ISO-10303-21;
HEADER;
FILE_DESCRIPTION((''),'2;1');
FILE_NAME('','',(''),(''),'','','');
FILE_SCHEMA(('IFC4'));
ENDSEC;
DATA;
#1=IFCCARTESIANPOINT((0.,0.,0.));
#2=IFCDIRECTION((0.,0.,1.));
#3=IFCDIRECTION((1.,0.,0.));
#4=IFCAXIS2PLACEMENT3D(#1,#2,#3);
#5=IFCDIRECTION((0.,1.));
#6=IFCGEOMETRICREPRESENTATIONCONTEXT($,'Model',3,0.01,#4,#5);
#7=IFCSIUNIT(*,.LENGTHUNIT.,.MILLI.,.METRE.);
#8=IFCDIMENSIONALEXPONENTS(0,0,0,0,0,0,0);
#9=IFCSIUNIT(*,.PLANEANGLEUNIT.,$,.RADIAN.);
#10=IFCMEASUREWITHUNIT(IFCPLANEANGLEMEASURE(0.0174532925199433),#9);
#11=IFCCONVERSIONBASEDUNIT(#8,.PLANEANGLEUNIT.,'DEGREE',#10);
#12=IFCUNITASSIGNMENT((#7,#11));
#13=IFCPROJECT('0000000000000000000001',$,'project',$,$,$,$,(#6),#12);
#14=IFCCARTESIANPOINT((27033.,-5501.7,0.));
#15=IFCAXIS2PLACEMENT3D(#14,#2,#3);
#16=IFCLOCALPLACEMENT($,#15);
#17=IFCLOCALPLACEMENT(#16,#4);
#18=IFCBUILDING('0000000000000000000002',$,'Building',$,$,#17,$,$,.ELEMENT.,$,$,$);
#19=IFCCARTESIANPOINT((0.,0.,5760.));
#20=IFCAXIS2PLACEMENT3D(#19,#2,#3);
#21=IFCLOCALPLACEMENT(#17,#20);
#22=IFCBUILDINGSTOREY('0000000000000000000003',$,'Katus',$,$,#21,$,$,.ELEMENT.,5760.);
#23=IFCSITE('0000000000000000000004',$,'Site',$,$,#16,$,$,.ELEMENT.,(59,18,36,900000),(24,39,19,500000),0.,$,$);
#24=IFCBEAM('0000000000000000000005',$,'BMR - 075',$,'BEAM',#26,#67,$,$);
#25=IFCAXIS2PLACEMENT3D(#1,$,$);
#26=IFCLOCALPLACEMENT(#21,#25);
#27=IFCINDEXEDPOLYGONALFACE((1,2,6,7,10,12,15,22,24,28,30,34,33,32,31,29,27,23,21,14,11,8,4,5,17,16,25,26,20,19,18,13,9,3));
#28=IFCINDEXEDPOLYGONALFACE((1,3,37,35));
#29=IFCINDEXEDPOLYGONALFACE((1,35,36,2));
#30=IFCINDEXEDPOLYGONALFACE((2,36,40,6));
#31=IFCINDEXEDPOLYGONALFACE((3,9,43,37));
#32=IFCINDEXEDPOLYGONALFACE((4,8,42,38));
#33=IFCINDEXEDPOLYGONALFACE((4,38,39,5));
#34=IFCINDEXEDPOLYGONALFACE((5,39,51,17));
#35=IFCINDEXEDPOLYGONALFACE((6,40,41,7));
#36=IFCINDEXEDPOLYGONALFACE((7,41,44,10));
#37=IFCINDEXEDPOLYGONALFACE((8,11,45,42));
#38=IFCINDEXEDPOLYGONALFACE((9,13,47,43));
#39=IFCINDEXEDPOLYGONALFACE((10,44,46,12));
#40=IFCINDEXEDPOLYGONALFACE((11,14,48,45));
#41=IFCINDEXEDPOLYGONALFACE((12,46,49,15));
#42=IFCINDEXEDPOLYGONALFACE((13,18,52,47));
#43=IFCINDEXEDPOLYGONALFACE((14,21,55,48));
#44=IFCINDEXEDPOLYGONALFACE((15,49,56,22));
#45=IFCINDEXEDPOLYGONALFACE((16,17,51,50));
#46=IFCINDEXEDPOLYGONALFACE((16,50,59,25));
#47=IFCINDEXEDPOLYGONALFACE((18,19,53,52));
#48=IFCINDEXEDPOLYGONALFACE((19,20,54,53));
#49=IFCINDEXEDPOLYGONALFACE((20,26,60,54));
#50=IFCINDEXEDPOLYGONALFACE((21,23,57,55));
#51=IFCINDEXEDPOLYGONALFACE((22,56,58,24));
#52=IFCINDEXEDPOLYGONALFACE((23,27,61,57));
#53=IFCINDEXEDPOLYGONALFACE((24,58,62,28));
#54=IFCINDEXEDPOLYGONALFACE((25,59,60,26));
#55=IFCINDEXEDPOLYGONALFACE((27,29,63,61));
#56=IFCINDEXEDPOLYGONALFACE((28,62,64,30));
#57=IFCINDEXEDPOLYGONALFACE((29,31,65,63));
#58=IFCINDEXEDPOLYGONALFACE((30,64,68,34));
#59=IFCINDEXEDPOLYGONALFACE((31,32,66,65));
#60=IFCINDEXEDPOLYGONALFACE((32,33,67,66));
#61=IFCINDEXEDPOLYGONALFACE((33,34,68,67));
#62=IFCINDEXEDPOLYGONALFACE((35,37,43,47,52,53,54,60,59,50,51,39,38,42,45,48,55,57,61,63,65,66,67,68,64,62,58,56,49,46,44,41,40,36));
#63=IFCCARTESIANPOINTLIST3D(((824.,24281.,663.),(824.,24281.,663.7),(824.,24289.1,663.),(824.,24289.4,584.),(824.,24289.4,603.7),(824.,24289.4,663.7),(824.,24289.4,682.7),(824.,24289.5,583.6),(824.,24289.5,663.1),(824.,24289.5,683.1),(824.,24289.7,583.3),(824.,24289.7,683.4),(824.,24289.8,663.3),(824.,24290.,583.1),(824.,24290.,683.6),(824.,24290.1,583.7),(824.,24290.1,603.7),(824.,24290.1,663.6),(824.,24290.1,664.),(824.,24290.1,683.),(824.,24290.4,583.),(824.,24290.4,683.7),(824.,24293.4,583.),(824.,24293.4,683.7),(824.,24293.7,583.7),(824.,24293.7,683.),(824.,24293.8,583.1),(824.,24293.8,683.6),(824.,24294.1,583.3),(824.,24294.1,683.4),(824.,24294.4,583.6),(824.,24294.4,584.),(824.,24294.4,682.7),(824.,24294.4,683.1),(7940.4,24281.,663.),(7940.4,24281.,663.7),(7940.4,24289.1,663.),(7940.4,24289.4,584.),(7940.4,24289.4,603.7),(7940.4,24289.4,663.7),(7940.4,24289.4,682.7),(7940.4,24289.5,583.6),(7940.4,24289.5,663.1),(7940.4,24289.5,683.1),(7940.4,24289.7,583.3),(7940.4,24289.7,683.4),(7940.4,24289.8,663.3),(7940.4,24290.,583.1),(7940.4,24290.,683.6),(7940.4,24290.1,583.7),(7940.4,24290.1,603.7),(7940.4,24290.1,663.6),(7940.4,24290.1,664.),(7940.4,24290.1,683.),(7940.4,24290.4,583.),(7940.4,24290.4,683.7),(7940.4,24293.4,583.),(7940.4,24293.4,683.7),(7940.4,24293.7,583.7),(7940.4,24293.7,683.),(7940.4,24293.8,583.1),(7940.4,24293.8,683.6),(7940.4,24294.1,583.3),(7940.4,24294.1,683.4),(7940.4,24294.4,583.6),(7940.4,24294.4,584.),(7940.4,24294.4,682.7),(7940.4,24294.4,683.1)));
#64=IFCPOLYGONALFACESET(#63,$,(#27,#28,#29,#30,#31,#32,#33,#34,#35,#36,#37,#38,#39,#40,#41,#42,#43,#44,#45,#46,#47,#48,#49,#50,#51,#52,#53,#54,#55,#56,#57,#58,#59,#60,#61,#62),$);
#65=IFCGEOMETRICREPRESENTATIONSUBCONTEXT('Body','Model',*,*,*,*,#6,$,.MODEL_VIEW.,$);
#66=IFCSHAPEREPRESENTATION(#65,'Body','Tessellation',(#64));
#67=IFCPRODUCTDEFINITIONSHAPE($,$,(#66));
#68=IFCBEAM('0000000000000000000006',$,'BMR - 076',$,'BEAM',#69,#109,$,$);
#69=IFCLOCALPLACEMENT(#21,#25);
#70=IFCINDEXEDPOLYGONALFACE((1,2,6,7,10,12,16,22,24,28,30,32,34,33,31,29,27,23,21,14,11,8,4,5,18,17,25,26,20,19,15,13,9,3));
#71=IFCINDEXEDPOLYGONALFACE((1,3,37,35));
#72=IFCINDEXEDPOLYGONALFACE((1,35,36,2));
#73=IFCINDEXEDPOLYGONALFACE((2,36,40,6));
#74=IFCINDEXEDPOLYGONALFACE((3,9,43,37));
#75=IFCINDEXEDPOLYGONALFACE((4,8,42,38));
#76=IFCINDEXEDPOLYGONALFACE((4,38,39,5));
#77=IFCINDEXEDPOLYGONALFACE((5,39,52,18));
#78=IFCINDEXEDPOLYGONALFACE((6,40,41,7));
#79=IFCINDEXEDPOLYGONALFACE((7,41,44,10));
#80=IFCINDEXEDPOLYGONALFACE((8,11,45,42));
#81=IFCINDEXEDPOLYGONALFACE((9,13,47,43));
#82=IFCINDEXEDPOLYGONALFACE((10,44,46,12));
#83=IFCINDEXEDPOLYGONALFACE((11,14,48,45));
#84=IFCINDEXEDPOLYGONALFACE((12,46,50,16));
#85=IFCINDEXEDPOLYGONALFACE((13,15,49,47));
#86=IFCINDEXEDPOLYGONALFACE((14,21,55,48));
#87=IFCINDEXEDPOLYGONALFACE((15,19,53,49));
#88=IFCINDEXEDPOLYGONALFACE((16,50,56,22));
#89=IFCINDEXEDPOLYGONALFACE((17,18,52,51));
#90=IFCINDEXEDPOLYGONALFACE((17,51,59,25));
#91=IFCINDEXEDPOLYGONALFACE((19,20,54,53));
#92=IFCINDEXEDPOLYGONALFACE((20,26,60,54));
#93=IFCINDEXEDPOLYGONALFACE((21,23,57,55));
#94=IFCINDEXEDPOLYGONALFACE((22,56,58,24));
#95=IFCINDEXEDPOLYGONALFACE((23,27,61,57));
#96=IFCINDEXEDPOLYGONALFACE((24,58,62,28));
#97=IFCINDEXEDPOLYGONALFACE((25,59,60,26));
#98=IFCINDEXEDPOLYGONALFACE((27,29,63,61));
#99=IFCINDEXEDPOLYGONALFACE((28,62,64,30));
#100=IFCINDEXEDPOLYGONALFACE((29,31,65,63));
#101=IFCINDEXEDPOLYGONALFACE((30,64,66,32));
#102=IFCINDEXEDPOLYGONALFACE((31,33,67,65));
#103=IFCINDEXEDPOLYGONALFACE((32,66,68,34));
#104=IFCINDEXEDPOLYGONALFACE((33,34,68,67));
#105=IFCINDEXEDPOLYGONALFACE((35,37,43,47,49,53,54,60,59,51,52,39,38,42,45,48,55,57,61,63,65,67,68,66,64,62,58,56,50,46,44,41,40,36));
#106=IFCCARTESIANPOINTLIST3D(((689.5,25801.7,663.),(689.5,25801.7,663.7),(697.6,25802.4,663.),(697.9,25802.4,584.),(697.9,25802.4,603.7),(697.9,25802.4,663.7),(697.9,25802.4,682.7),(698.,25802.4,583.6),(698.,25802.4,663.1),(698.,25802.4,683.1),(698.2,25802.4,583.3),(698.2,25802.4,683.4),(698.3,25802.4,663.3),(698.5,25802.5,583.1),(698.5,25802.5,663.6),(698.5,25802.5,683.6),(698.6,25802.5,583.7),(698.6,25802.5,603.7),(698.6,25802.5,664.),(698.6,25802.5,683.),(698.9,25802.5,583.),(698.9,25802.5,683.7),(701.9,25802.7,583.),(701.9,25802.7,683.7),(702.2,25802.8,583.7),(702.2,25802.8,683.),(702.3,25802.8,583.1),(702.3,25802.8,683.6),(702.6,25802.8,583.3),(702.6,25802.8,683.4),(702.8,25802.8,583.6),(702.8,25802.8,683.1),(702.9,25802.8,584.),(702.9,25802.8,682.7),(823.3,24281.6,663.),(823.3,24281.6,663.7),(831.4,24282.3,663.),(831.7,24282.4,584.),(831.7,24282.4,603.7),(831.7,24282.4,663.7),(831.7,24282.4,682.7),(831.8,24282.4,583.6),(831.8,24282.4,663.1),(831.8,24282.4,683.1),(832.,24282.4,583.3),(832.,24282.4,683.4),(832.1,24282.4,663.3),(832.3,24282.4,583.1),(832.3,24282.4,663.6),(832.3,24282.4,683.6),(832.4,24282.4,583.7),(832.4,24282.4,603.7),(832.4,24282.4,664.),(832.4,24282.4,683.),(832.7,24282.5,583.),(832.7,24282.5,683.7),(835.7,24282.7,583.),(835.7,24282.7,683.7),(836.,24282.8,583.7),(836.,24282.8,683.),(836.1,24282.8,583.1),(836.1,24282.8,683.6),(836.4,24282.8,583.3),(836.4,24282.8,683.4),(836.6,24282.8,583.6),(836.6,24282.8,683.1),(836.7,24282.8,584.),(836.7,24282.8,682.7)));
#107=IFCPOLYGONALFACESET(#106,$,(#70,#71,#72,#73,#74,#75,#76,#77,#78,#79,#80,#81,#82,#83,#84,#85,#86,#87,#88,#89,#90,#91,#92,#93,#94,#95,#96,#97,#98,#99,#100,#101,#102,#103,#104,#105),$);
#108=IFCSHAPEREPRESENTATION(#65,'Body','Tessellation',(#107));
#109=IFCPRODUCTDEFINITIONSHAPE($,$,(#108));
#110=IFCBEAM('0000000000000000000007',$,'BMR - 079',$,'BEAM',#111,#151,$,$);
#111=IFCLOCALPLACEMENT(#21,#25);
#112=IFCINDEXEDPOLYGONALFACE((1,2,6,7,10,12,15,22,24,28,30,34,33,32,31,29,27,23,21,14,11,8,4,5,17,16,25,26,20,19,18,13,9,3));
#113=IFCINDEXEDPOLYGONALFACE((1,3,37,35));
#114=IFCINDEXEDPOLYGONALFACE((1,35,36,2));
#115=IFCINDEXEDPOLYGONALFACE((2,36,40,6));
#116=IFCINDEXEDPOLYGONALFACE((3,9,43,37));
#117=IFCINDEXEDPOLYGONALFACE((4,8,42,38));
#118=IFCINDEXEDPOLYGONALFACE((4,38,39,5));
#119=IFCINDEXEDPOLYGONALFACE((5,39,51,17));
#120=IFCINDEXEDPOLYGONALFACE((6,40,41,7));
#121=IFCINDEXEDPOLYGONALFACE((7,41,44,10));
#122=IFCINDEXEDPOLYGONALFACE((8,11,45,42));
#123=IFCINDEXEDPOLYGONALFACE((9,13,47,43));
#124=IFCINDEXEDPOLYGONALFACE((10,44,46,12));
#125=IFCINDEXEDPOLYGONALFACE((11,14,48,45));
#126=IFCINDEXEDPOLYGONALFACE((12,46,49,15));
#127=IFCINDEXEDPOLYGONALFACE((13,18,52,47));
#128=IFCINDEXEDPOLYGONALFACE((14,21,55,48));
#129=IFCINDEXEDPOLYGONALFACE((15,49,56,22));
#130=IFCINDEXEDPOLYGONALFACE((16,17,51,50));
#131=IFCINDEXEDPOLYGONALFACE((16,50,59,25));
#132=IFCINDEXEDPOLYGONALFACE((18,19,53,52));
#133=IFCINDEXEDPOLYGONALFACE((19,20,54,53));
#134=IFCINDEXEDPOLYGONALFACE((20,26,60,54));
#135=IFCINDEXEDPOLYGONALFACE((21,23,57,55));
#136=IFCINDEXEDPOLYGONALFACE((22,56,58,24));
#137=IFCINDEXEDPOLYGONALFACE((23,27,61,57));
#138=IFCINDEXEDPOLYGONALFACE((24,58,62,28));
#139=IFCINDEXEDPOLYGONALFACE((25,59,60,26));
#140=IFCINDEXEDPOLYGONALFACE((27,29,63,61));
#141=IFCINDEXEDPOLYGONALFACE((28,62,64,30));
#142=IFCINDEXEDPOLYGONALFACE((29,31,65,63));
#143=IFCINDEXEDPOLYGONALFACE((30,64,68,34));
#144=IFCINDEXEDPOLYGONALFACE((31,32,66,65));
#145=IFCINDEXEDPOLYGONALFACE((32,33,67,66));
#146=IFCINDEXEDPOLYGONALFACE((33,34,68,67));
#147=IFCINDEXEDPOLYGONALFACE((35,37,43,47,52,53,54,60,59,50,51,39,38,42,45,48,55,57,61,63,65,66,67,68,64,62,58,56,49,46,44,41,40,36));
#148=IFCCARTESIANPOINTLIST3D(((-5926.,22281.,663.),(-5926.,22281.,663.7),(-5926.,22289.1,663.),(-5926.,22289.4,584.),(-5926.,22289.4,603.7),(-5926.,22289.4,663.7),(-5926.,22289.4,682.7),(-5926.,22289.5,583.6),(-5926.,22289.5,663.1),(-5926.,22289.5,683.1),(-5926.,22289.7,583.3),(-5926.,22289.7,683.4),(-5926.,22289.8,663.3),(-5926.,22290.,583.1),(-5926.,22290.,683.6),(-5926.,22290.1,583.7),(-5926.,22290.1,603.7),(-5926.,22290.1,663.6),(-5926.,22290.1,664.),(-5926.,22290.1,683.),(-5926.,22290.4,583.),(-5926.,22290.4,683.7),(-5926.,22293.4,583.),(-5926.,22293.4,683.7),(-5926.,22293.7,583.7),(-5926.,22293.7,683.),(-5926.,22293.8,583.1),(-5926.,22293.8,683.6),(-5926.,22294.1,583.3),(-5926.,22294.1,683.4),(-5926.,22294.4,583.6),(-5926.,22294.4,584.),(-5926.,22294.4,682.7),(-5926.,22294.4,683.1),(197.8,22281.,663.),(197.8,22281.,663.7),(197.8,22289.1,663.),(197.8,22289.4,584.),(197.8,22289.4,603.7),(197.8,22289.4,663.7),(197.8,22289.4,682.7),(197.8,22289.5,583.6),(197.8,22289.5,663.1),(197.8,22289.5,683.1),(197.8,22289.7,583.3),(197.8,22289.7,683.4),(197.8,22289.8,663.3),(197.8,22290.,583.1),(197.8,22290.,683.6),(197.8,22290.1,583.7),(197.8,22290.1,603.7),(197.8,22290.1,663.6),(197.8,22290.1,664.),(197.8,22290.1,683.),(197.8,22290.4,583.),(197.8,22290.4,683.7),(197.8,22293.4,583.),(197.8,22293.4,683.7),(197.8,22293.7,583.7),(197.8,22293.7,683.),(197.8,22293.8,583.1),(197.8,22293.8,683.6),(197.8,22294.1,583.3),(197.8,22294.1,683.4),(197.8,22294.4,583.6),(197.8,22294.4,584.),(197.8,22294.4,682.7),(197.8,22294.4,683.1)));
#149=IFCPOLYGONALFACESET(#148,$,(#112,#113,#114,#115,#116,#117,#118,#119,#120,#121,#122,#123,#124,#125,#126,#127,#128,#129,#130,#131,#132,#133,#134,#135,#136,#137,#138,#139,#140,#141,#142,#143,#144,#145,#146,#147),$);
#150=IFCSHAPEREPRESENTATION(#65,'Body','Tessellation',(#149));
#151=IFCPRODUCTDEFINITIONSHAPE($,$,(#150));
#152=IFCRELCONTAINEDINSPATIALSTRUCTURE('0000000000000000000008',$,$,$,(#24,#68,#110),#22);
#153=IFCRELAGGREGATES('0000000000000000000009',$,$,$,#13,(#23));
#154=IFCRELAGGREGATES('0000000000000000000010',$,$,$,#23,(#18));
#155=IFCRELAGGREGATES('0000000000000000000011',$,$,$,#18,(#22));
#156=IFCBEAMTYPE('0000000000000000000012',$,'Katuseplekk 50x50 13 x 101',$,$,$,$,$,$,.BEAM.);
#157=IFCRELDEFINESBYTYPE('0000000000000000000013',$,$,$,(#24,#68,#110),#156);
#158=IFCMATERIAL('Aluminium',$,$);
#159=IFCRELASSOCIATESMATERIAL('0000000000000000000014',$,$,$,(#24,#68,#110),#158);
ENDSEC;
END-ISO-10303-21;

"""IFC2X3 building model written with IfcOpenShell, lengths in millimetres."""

from ifc_helpers import new_model, entity, si_unit, converted_unit, point, direction, frame, frame_2d, origin_with_axes, place, context, subcontext, project, spatial, polyline, circle_curve, parameter, trimmed, segment, composite_curve, outline, extrude, material, type_object, element, save


model = new_model("IFC2X3")

# Units and contexts
model_context = context("Model", 3, precision=0.01, world=origin_with_axes(), true_north=direction((0.0, 1.0)))
body_context = subcontext(model_context, "Body", "Model", "MODEL_VIEW")
ifc_project = project(units=[si_unit("LENGTHUNIT", "METRE", prefix="MILLI"), converted_unit("PLANEANGLEUNIT", "DEGREE", entity("IfcPlaneAngleMeasure", 0.0174532925199433), si_unit("PLANEANGLEUNIT", "RADIAN"), dimensions=[0, 0, 0, 0, 0, 0, 0])], contexts=[model_context])

# Site, building, storey
site_placement = place(None, frame((27033.0, -5501.7, 0.0), z_axis=(0.0, 0.0, 1.0), x_axis=(1.0, 0.0, 0.0)))
site = spatial("IfcSite", under=ifc_project, at=site_placement, Name="Site", CompositionType="ELEMENT", RefLatitude=(59, 18, 36, 900000), RefLongitude=(24, 39, 19, 500000), RefElevation=0.0)
building_placement = place(site_placement, origin_with_axes())
building = spatial("IfcBuilding", under=site, at=building_placement, Name="Building", CompositionType="ELEMENT")
storey_placement = place(building_placement, frame((0.0, 0.0, 5760.0), z_axis=(0.0, 0.0, 1.0), x_axis=(1.0, 0.0, 0.0)))
storey = spatial("IfcBuildingStorey", under=building, at=storey_placement, Name="Katus", CompositionType="ELEMENT", Elevation=5760.0)

# Beams
ifc_material_1 = material(Name="Aluminium")
beam_type = type_object("IfcBeamType", Name="Katuseplekk 50x50 13 x 101", PredefinedType="BEAM")
beam_1_placement = place(storey_placement, frame((7940.4, 24281.7, 663.0), z_axis=(0.0, 0.0, 1.0), x_axis=(0.0, 1.0, 0.0)))
element("IfcBeam", 1, at=beam_1_placement, inside=storey, type_object=beam_type, material=ifc_material_1, Name="BMR - 075", ObjectType="BEAM", context=body_context, shape_type="SweptSolid", body=[
    extrude(outline(composite_curve([segment(polyline([(-0.7, 0.0), (7.4, 0.0)]), True, "CONTINUOUS"), segment(trimmed(circle_curve(frame_2d((7.4, 1.0), x_axis=(0.0, -1.0)), 1.0), [point((7.4, 0.0)), parameter(0.0)], [point((8.4, 1.0)), parameter(90.0)], True, "CARTESIAN"), True, "CONTINUOUS"), segment(polyline([(8.4, 1.0), (8.4, 20.0), (12.0, 20.0), (12.0, -79.3), (8.4, -79.3), (8.4, -59.3), (7.7, -59.3), (7.7, -79.0)]), True, "CONTINUOUS"), segment(trimmed(circle_curve(frame_2d((8.7, -79.0), x_axis=(-1.0, 0.0)), 1.0), [point((7.7, -79.0)), parameter(0.0)], [point((8.7, -80.0)), parameter(90.0)], True, "CARTESIAN"), True, "CONTINUOUS"), segment(polyline([(8.7, -80.0), (11.7, -80.0)]), True, "CONTINUOUS"), segment(trimmed(circle_curve(frame_2d((11.7, -79.0), x_axis=(0.0, -1.0)), 1.0), [point((11.7, -80.0)), parameter(0.0)], [point((12.7, -79.0)), parameter(90.0)], True, "CARTESIAN"), True, "CONTINUOUS"), segment(polyline([(12.7, -79.0), (12.7, 19.7)]), True, "CONTINUOUS"), segment(trimmed(circle_curve(frame_2d((11.7, 19.7), x_axis=(1.0, 0.0)), 1.0), [point((12.7, 19.7)), parameter(0.0)], [point((11.7, 20.7)), parameter(90.0)], True, "CARTESIAN"), True, "CONTINUOUS"), segment(polyline([(11.7, 20.7), (8.7, 20.7)]), True, "CONTINUOUS"), segment(trimmed(circle_curve(frame_2d((8.7, 19.7), x_axis=(0.0, 1.0)), 1.0), [point((8.7, 20.7)), parameter(0.0)], [point((7.7, 19.7)), parameter(90.0)], True, "CARTESIAN"), True, "CONTINUOUS"), segment(polyline([(7.7, 19.7), (7.7, 0.7), (-0.7, 0.7), (-0.7, 0.0)]), True, "CONTINUOUS")], self_intersect=False)), frame((0.0, 7116.4, 0.0), z_axis=(0.0, -1.0, 0.0), x_axis=(1.0, 0.0, 0.0)), (0.0, 0.0, 1.0), 7116.4),
])
beam_2_placement = place(storey_placement, frame((824.0, 24281.7, 663.0), z_axis=(0.0, 0.0, 1.0), x_axis=(0.996146, 0.087712, 0.0)))
element("IfcBeam", 2, at=beam_2_placement, inside=storey, type_object=beam_type, material=ifc_material_1, Name="BMR - 076", ObjectType="BEAM", context=body_context, shape_type="SweptSolid", body=[
    extrude(outline(composite_curve([segment(polyline([(-0.7, 0.0), (7.4, 0.0)]), True, "CONTINUOUS"), segment(trimmed(circle_curve(frame_2d((7.4, 1.0), x_axis=(0.0, -1.0)), 1.0), [point((7.4, 0.0)), parameter(0.0)], [point((8.4, 1.0)), parameter(90.0)], True, "CARTESIAN"), True, "CONTINUOUS"), segment(polyline([(8.4, 1.0), (8.4, 20.0), (12.0, 20.0), (12.0, -79.3), (8.4, -79.3), (8.4, -59.3), (7.7, -59.3), (7.7, -79.0)]), True, "CONTINUOUS"), segment(trimmed(circle_curve(frame_2d((8.7, -79.0), x_axis=(-1.0, 0.0)), 1.0), [point((7.7, -79.0)), parameter(0.0)], [point((8.7, -80.0)), parameter(90.0)], True, "CARTESIAN"), True, "CONTINUOUS"), segment(polyline([(8.7, -80.0), (11.7, -80.0)]), True, "CONTINUOUS"), segment(trimmed(circle_curve(frame_2d((11.7, -79.0), x_axis=(0.0, -1.0)), 1.0), [point((11.7, -80.0)), parameter(0.0)], [point((12.7, -79.0)), parameter(90.0)], True, "CARTESIAN"), True, "CONTINUOUS"), segment(polyline([(12.7, -79.0), (12.7, 19.7)]), True, "CONTINUOUS"), segment(trimmed(circle_curve(frame_2d((11.7, 19.7), x_axis=(1.0, 0.0)), 1.0), [point((12.7, 19.7)), parameter(0.0)], [point((11.7, 20.7)), parameter(90.0)], True, "CARTESIAN"), True, "CONTINUOUS"), segment(polyline([(11.7, 20.7), (8.7, 20.7)]), True, "CONTINUOUS"), segment(trimmed(circle_curve(frame_2d((8.7, 19.7), x_axis=(0.0, 1.0)), 1.0), [point((8.7, 20.7)), parameter(0.0)], [point((7.7, 19.7)), parameter(90.0)], True, "CARTESIAN"), True, "CONTINUOUS"), segment(polyline([(7.7, 19.7), (7.7, 0.7), (-0.7, 0.7), (-0.7, 0.0)]), True, "CONTINUOUS")], self_intersect=False)), frame((0.0, 1525.9, 0.0), z_axis=(0.0, -1.0, 0.0), x_axis=(1.0, 0.0, 0.0)), (0.0, 0.0, 1.0), 1525.9),
])
beam_3_placement = place(storey_placement, frame((197.8, 22281.7, 663.0), z_axis=(0.0, 0.0, 1.0), x_axis=(0.0, 1.0, 0.0)))
element("IfcBeam", 3, at=beam_3_placement, inside=storey, type_object=beam_type, material=ifc_material_1, Name="BMR - 079", ObjectType="BEAM", context=body_context, shape_type="SweptSolid", body=[
    extrude(outline(composite_curve([segment(polyline([(-0.7, 0.0), (7.4, 0.0)]), True, "CONTINUOUS"), segment(trimmed(circle_curve(frame_2d((7.4, 1.0), x_axis=(0.0, -1.0)), 1.0), [point((7.4, 0.0)), parameter(0.0)], [point((8.4, 1.0)), parameter(90.0)], True, "CARTESIAN"), True, "CONTINUOUS"), segment(polyline([(8.4, 1.0), (8.4, 20.0), (12.0, 20.0), (12.0, -79.3), (8.4, -79.3), (8.4, -59.3), (7.7, -59.3), (7.7, -79.0)]), True, "CONTINUOUS"), segment(trimmed(circle_curve(frame_2d((8.7, -79.0), x_axis=(-1.0, 0.0)), 1.0), [point((7.7, -79.0)), parameter(0.0)], [point((8.7, -80.0)), parameter(90.0)], True, "CARTESIAN"), True, "CONTINUOUS"), segment(polyline([(8.7, -80.0), (11.7, -80.0)]), True, "CONTINUOUS"), segment(trimmed(circle_curve(frame_2d((11.7, -79.0), x_axis=(0.0, -1.0)), 1.0), [point((11.7, -80.0)), parameter(0.0)], [point((12.7, -79.0)), parameter(90.0)], True, "CARTESIAN"), True, "CONTINUOUS"), segment(polyline([(12.7, -79.0), (12.7, 19.7)]), True, "CONTINUOUS"), segment(trimmed(circle_curve(frame_2d((11.7, 19.7), x_axis=(1.0, 0.0)), 1.0), [point((12.7, 19.7)), parameter(0.0)], [point((11.7, 20.7)), parameter(90.0)], True, "CARTESIAN"), True, "CONTINUOUS"), segment(polyline([(11.7, 20.7), (8.7, 20.7)]), True, "CONTINUOUS"), segment(trimmed(circle_curve(frame_2d((8.7, 19.7), x_axis=(0.0, 1.0)), 1.0), [point((8.7, 20.7)), parameter(0.0)], [point((7.7, 19.7)), parameter(90.0)], True, "CARTESIAN"), True, "CONTINUOUS"), segment(polyline([(7.7, 19.7), (7.7, 0.7), (-0.7, 0.7), (-0.7, 0.0)]), True, "CONTINUOUS")], self_intersect=False)), frame((0.0, 6123.8, 0.0), z_axis=(0.0, -1.0, 0.0), x_axis=(1.0, 0.0, 0.0)), (0.0, 0.0, 1.0), 6123.8),
])

save(model, "model.ifc")
